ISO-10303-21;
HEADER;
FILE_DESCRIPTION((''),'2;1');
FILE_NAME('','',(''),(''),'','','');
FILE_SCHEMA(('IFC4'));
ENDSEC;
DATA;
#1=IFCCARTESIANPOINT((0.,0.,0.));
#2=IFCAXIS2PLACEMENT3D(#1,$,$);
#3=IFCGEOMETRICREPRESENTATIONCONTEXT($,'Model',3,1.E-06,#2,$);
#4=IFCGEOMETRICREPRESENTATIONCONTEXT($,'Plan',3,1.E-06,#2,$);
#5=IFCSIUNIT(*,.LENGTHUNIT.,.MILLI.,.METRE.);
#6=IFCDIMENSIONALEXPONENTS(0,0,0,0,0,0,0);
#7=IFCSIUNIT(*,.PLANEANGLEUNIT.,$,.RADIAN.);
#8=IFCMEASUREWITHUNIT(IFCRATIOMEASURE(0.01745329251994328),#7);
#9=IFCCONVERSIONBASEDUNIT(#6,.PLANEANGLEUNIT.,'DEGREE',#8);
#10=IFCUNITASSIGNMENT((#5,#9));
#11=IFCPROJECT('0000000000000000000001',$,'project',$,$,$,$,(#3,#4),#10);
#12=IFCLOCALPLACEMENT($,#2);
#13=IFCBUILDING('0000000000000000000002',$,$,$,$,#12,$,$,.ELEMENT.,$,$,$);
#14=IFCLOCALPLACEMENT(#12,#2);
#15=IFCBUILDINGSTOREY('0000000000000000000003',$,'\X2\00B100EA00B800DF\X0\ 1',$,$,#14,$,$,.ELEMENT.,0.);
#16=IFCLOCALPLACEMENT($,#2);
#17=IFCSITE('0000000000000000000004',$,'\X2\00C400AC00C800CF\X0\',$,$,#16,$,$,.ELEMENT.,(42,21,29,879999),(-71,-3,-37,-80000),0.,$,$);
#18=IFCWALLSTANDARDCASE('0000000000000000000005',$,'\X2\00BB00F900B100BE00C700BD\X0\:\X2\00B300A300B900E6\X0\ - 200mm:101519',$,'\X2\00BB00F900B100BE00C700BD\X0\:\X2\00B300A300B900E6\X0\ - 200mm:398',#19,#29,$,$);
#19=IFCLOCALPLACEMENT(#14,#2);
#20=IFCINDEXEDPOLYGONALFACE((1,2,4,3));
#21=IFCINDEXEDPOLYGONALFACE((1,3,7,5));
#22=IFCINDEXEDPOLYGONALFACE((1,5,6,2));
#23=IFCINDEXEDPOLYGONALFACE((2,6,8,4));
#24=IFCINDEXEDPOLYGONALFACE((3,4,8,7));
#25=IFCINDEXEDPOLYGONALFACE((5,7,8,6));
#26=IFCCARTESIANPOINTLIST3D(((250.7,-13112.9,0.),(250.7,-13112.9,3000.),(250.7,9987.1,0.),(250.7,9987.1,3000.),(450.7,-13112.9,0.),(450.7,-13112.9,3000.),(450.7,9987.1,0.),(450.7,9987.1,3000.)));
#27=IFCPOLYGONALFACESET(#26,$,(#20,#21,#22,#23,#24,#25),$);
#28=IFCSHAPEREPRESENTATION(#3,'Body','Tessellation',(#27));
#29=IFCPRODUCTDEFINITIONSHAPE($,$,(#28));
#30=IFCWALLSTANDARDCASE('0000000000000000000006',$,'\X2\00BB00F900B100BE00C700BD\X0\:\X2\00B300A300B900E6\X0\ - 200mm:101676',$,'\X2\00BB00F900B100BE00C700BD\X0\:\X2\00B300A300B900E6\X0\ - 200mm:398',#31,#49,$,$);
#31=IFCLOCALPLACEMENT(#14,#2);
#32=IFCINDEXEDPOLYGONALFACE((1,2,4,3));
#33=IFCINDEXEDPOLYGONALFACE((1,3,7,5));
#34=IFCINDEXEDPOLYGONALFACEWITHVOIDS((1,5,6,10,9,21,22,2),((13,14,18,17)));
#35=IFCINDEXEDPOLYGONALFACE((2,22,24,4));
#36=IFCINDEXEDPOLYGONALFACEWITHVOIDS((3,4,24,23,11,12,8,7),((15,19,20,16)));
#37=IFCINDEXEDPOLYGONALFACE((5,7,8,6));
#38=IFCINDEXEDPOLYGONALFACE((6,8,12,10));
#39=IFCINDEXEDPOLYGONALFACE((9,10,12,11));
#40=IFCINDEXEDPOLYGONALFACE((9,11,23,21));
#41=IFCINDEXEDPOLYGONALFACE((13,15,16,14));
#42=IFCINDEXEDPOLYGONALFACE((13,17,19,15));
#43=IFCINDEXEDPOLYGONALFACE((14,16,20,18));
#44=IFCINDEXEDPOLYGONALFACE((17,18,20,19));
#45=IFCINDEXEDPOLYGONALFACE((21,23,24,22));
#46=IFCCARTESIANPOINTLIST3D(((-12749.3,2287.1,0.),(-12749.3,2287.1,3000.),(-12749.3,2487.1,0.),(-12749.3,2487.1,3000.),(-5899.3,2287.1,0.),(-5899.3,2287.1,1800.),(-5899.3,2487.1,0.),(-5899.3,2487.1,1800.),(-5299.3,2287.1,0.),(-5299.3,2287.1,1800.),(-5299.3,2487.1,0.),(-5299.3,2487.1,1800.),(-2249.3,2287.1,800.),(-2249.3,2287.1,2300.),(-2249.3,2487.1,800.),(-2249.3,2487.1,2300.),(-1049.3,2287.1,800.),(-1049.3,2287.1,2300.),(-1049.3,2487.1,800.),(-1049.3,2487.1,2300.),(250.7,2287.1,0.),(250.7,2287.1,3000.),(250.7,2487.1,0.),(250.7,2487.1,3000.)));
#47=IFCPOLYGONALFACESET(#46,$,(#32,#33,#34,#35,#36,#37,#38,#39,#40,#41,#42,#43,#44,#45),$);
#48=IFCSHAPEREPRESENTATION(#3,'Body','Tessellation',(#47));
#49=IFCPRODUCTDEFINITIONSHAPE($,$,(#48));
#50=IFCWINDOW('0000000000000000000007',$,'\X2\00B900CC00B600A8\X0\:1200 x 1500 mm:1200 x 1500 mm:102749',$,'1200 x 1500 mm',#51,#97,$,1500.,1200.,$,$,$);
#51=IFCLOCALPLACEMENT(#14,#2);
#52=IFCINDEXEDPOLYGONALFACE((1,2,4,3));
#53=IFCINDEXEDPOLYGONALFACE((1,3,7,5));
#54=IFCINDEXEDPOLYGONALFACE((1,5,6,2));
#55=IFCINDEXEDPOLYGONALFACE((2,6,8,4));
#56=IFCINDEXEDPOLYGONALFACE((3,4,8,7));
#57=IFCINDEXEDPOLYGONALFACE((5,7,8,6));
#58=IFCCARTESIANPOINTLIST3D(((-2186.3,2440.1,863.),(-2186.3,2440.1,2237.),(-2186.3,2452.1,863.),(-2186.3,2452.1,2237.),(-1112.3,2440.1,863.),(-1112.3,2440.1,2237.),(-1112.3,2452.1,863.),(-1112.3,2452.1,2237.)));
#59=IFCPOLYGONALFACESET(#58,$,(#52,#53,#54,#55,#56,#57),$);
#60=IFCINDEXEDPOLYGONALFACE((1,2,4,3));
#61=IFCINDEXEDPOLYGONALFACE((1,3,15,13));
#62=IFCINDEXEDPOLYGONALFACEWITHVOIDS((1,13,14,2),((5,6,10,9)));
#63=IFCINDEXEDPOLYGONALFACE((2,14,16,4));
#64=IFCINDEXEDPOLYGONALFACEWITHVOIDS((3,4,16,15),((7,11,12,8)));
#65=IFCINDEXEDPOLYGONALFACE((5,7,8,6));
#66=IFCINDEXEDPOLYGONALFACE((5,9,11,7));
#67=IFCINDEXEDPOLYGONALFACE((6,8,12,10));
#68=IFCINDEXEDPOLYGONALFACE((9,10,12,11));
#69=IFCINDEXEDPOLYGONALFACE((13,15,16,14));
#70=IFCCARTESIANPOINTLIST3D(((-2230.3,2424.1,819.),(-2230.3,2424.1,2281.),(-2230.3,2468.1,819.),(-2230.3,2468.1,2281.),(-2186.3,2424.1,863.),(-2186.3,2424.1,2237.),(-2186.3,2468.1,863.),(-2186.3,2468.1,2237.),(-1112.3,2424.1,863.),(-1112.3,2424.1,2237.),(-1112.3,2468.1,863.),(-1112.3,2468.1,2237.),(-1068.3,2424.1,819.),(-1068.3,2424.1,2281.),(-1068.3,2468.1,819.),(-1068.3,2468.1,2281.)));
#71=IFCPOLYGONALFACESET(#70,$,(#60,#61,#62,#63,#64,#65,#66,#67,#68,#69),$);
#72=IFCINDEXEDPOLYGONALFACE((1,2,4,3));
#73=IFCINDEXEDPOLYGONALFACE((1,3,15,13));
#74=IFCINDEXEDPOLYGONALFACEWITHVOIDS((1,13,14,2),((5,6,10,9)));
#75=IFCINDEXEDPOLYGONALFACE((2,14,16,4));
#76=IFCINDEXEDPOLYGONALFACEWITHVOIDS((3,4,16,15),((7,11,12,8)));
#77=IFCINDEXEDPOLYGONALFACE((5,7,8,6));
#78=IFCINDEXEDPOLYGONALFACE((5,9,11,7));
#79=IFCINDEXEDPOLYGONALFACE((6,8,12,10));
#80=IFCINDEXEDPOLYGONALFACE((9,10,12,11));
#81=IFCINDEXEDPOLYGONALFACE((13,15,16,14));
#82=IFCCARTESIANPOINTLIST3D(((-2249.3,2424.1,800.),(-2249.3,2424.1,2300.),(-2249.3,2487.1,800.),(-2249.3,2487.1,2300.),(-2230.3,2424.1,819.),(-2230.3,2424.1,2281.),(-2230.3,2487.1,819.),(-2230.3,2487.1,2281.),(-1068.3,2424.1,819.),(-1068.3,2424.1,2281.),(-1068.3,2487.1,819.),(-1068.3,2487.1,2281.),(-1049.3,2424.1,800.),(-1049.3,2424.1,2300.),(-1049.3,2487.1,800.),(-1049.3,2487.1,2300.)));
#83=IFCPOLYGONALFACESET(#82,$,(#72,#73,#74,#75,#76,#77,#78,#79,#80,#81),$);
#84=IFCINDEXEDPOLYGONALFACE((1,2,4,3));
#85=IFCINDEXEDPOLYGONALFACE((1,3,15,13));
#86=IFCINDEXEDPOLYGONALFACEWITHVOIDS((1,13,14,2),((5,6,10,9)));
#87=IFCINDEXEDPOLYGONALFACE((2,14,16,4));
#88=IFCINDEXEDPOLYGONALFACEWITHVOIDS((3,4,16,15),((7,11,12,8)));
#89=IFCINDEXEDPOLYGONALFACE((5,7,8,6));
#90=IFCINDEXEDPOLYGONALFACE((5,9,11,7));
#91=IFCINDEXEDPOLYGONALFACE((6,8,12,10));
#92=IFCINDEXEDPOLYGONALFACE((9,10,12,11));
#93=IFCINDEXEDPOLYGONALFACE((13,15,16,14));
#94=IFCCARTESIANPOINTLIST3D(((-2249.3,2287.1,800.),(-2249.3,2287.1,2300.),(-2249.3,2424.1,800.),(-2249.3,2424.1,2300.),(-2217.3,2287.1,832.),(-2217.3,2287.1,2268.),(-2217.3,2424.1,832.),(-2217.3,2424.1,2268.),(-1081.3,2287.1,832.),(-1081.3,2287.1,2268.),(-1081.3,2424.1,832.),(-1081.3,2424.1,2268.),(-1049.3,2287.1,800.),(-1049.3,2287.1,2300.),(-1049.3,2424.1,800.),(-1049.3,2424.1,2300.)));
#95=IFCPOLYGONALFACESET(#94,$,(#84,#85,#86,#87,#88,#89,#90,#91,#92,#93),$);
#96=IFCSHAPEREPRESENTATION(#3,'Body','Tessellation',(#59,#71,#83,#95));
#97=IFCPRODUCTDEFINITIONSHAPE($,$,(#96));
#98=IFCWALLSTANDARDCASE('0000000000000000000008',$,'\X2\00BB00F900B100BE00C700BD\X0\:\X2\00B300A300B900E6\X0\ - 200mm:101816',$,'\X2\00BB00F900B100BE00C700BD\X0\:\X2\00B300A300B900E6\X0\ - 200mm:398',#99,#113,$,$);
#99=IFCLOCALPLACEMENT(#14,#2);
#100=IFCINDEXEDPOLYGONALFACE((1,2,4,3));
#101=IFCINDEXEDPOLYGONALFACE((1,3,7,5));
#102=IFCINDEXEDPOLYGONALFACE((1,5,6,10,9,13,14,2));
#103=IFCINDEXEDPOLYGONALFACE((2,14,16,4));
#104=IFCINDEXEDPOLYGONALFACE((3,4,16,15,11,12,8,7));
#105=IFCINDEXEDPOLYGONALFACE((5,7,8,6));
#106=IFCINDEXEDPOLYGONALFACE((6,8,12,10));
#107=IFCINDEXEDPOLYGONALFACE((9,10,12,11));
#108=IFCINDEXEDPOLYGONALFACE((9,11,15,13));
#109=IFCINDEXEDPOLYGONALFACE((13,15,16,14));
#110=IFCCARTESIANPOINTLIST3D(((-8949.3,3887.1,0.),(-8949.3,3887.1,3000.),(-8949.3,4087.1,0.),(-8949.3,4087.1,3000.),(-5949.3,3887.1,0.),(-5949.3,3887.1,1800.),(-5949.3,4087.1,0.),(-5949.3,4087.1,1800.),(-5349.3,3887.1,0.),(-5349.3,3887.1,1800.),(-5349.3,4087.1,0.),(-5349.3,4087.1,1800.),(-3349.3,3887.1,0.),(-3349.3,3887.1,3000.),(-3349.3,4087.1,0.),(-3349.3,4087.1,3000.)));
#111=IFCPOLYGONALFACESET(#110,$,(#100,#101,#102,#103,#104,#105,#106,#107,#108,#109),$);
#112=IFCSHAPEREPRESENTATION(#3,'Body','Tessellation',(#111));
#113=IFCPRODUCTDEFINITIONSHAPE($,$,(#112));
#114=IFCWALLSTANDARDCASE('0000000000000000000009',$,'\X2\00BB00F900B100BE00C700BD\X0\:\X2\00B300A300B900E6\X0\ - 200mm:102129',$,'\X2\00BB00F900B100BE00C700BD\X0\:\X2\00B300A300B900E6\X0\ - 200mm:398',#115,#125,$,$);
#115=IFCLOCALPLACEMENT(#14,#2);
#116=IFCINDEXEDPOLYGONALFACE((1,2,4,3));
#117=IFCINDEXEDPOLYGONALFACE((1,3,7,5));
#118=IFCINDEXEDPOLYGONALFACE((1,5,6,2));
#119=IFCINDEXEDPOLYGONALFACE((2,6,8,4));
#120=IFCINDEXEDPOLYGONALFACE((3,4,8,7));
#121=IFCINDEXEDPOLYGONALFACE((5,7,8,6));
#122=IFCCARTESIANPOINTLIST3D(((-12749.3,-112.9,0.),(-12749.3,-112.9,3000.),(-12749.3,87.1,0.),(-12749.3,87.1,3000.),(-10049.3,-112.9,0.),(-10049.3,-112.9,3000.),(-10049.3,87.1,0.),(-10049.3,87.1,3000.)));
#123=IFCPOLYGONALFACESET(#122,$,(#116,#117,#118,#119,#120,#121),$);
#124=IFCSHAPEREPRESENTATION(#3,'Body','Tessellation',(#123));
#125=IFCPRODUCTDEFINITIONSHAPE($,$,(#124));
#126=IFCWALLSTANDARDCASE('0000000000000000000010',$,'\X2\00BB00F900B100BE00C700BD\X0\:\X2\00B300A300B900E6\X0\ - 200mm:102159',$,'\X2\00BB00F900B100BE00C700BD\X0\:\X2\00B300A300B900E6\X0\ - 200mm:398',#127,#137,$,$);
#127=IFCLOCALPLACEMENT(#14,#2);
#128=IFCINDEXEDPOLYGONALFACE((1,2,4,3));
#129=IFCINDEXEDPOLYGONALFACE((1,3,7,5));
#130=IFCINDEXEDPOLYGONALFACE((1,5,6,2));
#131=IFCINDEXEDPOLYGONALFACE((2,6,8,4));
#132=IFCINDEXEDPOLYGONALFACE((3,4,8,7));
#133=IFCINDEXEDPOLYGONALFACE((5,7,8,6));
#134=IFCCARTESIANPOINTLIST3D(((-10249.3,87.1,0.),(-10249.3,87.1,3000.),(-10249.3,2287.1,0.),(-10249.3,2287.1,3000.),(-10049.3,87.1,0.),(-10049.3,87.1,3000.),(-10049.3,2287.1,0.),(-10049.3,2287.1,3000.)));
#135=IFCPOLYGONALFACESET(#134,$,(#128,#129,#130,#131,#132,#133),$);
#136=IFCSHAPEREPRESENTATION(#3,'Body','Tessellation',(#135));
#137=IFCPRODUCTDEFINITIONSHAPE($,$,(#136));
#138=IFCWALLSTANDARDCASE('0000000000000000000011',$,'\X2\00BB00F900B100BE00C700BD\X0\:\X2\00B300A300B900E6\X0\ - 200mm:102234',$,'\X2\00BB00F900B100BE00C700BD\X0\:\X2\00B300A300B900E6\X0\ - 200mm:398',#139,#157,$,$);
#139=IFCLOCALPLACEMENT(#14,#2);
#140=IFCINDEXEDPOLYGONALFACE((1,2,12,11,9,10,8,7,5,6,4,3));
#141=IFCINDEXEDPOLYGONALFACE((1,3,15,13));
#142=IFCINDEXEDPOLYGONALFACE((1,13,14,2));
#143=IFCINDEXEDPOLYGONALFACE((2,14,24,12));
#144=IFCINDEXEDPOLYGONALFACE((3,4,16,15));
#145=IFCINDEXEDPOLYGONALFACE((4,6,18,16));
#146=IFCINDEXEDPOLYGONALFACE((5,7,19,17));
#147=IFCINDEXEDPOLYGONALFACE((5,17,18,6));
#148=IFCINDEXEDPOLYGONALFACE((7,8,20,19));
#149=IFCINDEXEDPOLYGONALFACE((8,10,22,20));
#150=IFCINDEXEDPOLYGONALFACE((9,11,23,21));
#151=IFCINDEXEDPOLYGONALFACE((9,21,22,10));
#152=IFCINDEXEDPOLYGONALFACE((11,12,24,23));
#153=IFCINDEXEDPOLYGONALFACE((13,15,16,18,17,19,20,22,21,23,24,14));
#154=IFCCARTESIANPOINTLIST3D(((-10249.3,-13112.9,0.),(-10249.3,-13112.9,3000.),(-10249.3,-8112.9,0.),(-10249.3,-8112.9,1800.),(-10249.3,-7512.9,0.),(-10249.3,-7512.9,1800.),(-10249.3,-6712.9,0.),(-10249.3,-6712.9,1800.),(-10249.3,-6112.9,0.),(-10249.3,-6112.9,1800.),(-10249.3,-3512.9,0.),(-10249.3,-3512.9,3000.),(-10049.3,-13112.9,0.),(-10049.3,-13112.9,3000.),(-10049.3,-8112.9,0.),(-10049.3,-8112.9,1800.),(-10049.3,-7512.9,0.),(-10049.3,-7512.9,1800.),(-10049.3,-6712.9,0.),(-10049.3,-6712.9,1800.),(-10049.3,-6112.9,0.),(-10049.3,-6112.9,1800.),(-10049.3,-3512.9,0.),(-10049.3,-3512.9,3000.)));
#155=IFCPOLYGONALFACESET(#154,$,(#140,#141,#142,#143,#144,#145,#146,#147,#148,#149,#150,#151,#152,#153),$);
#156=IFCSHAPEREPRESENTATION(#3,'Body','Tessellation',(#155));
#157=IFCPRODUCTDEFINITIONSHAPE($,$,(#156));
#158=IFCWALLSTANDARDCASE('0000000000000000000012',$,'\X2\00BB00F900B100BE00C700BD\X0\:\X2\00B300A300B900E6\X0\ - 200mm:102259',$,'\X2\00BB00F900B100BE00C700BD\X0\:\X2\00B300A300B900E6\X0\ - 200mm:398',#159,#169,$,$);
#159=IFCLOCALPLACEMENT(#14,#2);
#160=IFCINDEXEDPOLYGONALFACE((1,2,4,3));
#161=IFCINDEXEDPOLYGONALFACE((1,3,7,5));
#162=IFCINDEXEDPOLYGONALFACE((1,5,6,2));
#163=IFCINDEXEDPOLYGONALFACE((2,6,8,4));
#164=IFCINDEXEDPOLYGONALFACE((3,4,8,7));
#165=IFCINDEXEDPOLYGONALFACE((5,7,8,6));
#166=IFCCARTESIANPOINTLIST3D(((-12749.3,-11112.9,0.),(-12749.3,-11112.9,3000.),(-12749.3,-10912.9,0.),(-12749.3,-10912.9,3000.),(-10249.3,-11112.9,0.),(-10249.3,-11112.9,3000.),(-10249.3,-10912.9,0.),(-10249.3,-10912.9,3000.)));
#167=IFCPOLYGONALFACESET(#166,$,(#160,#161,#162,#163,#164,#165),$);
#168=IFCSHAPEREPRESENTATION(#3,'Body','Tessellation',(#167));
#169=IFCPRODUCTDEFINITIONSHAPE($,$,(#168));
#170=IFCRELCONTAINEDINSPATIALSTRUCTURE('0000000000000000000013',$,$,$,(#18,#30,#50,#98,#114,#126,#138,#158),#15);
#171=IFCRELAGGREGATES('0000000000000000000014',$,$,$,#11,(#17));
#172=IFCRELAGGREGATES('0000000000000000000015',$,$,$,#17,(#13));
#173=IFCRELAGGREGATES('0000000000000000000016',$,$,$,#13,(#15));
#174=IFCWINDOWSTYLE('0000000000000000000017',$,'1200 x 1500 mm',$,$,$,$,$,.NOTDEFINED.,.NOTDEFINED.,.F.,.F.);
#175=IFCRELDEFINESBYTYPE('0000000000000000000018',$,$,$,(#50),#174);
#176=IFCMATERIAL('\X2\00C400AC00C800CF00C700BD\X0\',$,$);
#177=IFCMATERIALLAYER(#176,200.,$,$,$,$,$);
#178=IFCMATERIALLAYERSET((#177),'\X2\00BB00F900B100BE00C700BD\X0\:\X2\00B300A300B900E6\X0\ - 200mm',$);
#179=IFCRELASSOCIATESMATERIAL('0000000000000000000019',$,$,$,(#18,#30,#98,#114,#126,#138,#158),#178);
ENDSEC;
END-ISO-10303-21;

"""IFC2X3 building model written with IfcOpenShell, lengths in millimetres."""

from ifc_helpers import new_model, entity, si_unit, converted_unit, frame, frame_2d, origin, origin_2d_with_axis, place, context, project, spatial, polyline, rectangle, outline, extrude, source, transform, mapped, material, layer, layer_set, layer_usage, type_object, type_shapes, element, fill, save


model = new_model("IFC2X3")

# Units and contexts
model_context = context("Model", 3, precision=1e-06, world=origin())
plan_context = context("Plan", 3, precision=1e-06, world=origin())
ifc_project = project(units=[si_unit("LENGTHUNIT", "METRE", prefix="MILLI"), converted_unit("PLANEANGLEUNIT", "DEGREE", entity("IfcRatioMeasure", 0.01745329251994328), si_unit("PLANEANGLEUNIT", "RADIAN"), dimensions=[0, 0, 0, 0, 0, 0, 0])], contexts=[model_context, plan_context])

# Site, building, storey
site_placement = place(None, origin())
site = spatial("IfcSite", under=ifc_project, at=site_placement, Name="Ä¬ÈÏ", CompositionType="ELEMENT", RefLatitude=(42, 21, 29, 879999), RefLongitude=(-71, -3, -37, -80000), RefElevation=0.0)
building_placement = place(None, origin())
building = spatial("IfcBuilding", under=site, at=building_placement, CompositionType="ELEMENT")
storey_placement = place(building_placement, origin())
storey = spatial("IfcBuildingStorey", under=building, at=storey_placement, Name="±ê¸ß 1", CompositionType="ELEMENT", Elevation=0.0)

# Shared definitions
ifc_material_1 = material(Name="Ä¬ÈÏÇ½")
ifc_layer_1 = layer(ifc_material_1, 200.0)
ifc_layer_set_1 = layer_set([ifc_layer_1], Name="»ù±¾Ç½:³£¹æ - 200mm")
window_style = type_object("IfcWindowStyle", Name="1200 x 1500 mm", ConstructionType="NOTDEFINED", OperationType="NOTDEFINED", ParameterTakesPrecedence=False, Sizeable=False)
shared_shape = source(origin(), model_context, "Body", "SweptSolid", [
    extrude(rectangle(XDim=12.0, YDim=1074.0, at=origin_2d_with_axis()), frame((600.0, 159.0, 63.0), z_axis=(0.0, 0.0, 1.0), x_axis=(0.0, -1.0, 0.0)), (0.0, 0.0, 1.0), 1374.0),
    extrude(outline(polyline([(-581.0, -731.0), (581.0, -731.0), (581.0, 731.0), (-581.0, 731.0), (-581.0, -731.0)]), holes=[polyline([(-537.0, -687.0), (-537.0, 687.0), (537.0, 687.0), (537.0, -687.0), (-537.0, -687.0)])]), frame((600.0, 137.0, 750.0), z_axis=(0.0, 1.0, 0.0), x_axis=(1.0, 0.0, 0.0)), (0.0, 0.0, 1.0), 44.0),
    extrude(outline(polyline([(-600.0, -750.0), (600.0, -750.0), (600.0, 750.0), (-600.0, 750.0), (-600.0, -750.0)]), holes=[polyline([(-581.0, -731.0), (-581.0, 731.0), (581.0, 731.0), (581.0, -731.0), (-581.0, -731.0)])]), frame((600.0, 137.0, 750.0), z_axis=(0.0, 1.0, 0.0), x_axis=(1.0, 0.0, 0.0)), (0.0, 0.0, 1.0), 63.0),
    extrude(outline(polyline([(-600.0, -750.0), (600.0, -750.0), (600.0, 750.0), (-600.0, 750.0), (-600.0, -750.0)]), holes=[polyline([(-568.0, -718.0), (-568.0, 718.0), (568.0, 718.0), (568.0, -718.0), (-568.0, -718.0)])]), frame((600.0, 0.0, 750.0), z_axis=(0.0, 1.0, 0.0), x_axis=(1.0, 0.0, 0.0)), (0.0, 0.0, 1.0), 137.0),
])
type_shapes(window_style, [shared_shape])

# Wall
ifc_layer_usage_1 = layer_usage(ifc_layer_set_1, "AXIS2", "NEGATIVE", 100.0)
wall_1_placement = place(storey_placement, frame((350.7, -13112.9, 0.0), z_axis=(0.0, 0.0, 1.0), x_axis=(0.0, 1.0, 0.0)))
element("IfcWallStandardCase", 1, at=wall_1_placement, inside=storey, material=ifc_layer_usage_1, Name="»ù±¾Ç½:³£¹æ - 200mm:101519", ObjectType="»ù±¾Ç½:³£¹æ - 200mm:398", context=model_context, shape_type="SweptSolid", body=[
    extrude(rectangle(XDim=23100.0, YDim=200.0, at=frame_2d((11550.0, 0.0), x_axis=(-1.0, 0.0))), origin(), (0.0, 0.0, 1.0), 3000.0),
])

# Wall, openings, window
ifc_layer_usage_2 = layer_usage(ifc_layer_set_1, "AXIS2", "NEGATIVE", 100.0)
wall_2_placement = place(storey_placement, frame((-12749.3, 2387.1, 0.0)))
wall_2 = element("IfcWallStandardCase", 2, at=wall_2_placement, inside=storey, material=ifc_layer_usage_2, Name="»ù±¾Ç½:³£¹æ - 200mm:101676", ObjectType="»ù±¾Ç½:³£¹æ - 200mm:398", context=model_context, shape_type="SweptSolid", body=[
    extrude(rectangle(XDim=13000.0, YDim=200.0, at=frame_2d((6500.0, 0.0), x_axis=(-1.0, 0.0))), origin(), (0.0, 0.0, 1.0), 3000.0),
])
opening_1_placement = place(wall_2_placement, frame((10500.0, -100.0, 800.0)))
opening_1 = element("IfcOpeningElement", 3, at=opening_1_placement, cuts=wall_2, ObjectType="Opening", context=model_context, shape_type="SweptSolid", body=[
    extrude(rectangle(XDim=1500.0, YDim=1200.0, at=frame_2d((750.0, 600.0), x_axis=(1.0, 0.0))), frame((0.0, 0.0, 0.0), z_axis=(0.0, 1.0, 0.0), x_axis=(0.0, 0.0, 1.0)), (0.0, 0.0, 1.0), 200.0),
])
opening_2_placement = place(wall_2_placement, frame((7450.0, 100.0, 0.0)))
element("IfcOpeningElement", 4, at=opening_2_placement, cuts=wall_2, ObjectType="Opening", context=model_context, shape_type="SweptSolid", body=[
    extrude(rectangle(XDim=1800.0, YDim=600.0, at=frame_2d((900.0, 300.0), x_axis=(1.0, 0.0))), frame((0.0, 0.0, 0.0), z_axis=(0.0, -1.0, 0.0), x_axis=(0.0, 0.0, 1.0)), (0.0, 0.0, 1.0), 200.0),
])
window_1_placement = place(opening_1_placement, origin())
window_1 = element("IfcWindow", 5, at=window_1_placement, inside=storey, type_object=window_style, Name="¹Ì¶¨:1200 x 1500 mm:1200 x 1500 mm:102749", ObjectType="1200 x 1500 mm", OverallHeight=1500.0, OverallWidth=1200.0, context=model_context, shape_type="MappedRepresentation", body=[
    mapped(shared_shape, transform((0.0, 0.0, 0.0), scale=1.0)),
])
fill(opening_1, window_1)

# Wall, opening
ifc_layer_usage_3 = layer_usage(ifc_layer_set_1, "AXIS2", "NEGATIVE", 100.0)
wall_3_placement = place(storey_placement, frame((-8949.3, 3987.1, 0.0)))
wall_3 = element("IfcWallStandardCase", 6, at=wall_3_placement, inside=storey, material=ifc_layer_usage_3, Name="»ù±¾Ç½:³£¹æ - 200mm:101816", ObjectType="»ù±¾Ç½:³£¹æ - 200mm:398", context=model_context, shape_type="SweptSolid", body=[
    extrude(rectangle(XDim=5600.0, YDim=200.0, at=frame_2d((2800.0, 0.0), x_axis=(-1.0, 0.0))), origin(), (0.0, 0.0, 1.0), 3000.0),
])
opening_3_placement = place(wall_3_placement, frame((3000.0, -100.0, 0.0)))
element("IfcOpeningElement", 7, at=opening_3_placement, cuts=wall_3, ObjectType="Opening", context=model_context, shape_type="SweptSolid", body=[
    extrude(rectangle(XDim=1800.0, YDim=600.0, at=frame_2d((900.0, 300.0), x_axis=(1.0, 0.0))), frame((0.0, 0.0, 0.0), z_axis=(0.0, 1.0, 0.0), x_axis=(0.0, 0.0, 1.0)), (0.0, 0.0, 1.0), 200.0),
])

# Walls
ifc_layer_usage_4 = layer_usage(ifc_layer_set_1, "AXIS2", "NEGATIVE", 100.0)
wall_4_placement = place(storey_placement, frame((-12749.3, -12.9, 0.0)))
element("IfcWallStandardCase", 8, at=wall_4_placement, inside=storey, material=ifc_layer_usage_4, Name="»ù±¾Ç½:³£¹æ - 200mm:102129", ObjectType="»ù±¾Ç½:³£¹æ - 200mm:398", context=model_context, shape_type="SweptSolid", body=[
    extrude(rectangle(XDim=2700.0, YDim=200.0, at=frame_2d((1350.0, 0.0), x_axis=(-1.0, 0.0))), origin(), (0.0, 0.0, 1.0), 3000.0),
])
ifc_layer_usage_5 = layer_usage(ifc_layer_set_1, "AXIS2", "NEGATIVE", 100.0)
wall_5_placement = place(storey_placement, frame((-10149.3, 87.1, 0.0), z_axis=(0.0, 0.0, 1.0), x_axis=(0.0, 1.0, 0.0)))
element("IfcWallStandardCase", 9, at=wall_5_placement, inside=storey, material=ifc_layer_usage_5, Name="»ù±¾Ç½:³£¹æ - 200mm:102159", ObjectType="»ù±¾Ç½:³£¹æ - 200mm:398", context=model_context, shape_type="SweptSolid", body=[
    extrude(rectangle(XDim=2200.0, YDim=200.0, at=frame_2d((1100.0, 0.0), x_axis=(-1.0, 0.0))), origin(), (0.0, 0.0, 1.0), 3000.0),
])

# Wall, openings
ifc_layer_usage_6 = layer_usage(ifc_layer_set_1, "AXIS2", "NEGATIVE", 100.0)
wall_6_placement = place(storey_placement, frame((-10149.3, -3512.9, 0.0), z_axis=(0.0, 0.0, 1.0), x_axis=(0.0, -1.0, 0.0)))
wall_6 = element("IfcWallStandardCase", 10, at=wall_6_placement, inside=storey, material=ifc_layer_usage_6, Name="»ù±¾Ç½:³£¹æ - 200mm:102234", ObjectType="»ù±¾Ç½:³£¹æ - 200mm:398", context=model_context, shape_type="SweptSolid", body=[
    extrude(rectangle(XDim=9600.0, YDim=200.0, at=frame_2d((4800.0, 0.0), x_axis=(-1.0, 0.0))), origin(), (0.0, 0.0, 1.0), 3000.0),
])
opening_4_placement = place(wall_6_placement, frame((2600.0, -100.0, 0.0)))
element("IfcOpeningElement", 11, at=opening_4_placement, cuts=wall_6, ObjectType="Opening", context=model_context, shape_type="SweptSolid", body=[
    extrude(rectangle(XDim=1800.0, YDim=600.0, at=frame_2d((900.0, 300.0), x_axis=(1.0, 0.0))), frame((0.0, 0.0, 0.0), z_axis=(0.0, 1.0, 0.0), x_axis=(0.0, 0.0, 1.0)), (0.0, 0.0, 1.0), 200.0),
])
opening_5_placement = place(wall_6_placement, frame((4000.0, -100.0, 0.0)))
element("IfcOpeningElement", 12, at=opening_5_placement, cuts=wall_6, ObjectType="Opening", context=model_context, shape_type="SweptSolid", body=[
    extrude(rectangle(XDim=1800.0, YDim=600.0, at=frame_2d((900.0, 300.0), x_axis=(1.0, 0.0))), frame((0.0, 0.0, 0.0), z_axis=(0.0, 1.0, 0.0), x_axis=(0.0, 0.0, 1.0)), (0.0, 0.0, 1.0), 200.0),
])

# Wall
ifc_layer_usage_7 = layer_usage(ifc_layer_set_1, "AXIS2", "NEGATIVE", 100.0)
wall_7_placement = place(storey_placement, frame((-12749.3, -11012.9, 0.0)))
element("IfcWallStandardCase", 13, at=wall_7_placement, inside=storey, material=ifc_layer_usage_7, Name="»ù±¾Ç½:³£¹æ - 200mm:102259", ObjectType="»ù±¾Ç½:³£¹æ - 200mm:398", context=model_context, shape_type="SweptSolid", body=[
    extrude(rectangle(XDim=2500.0, YDim=200.0, at=frame_2d((1250.0, 0.0), x_axis=(-1.0, 0.0))), origin(), (0.0, 0.0, 1.0), 3000.0),
])

save(model, "model.ifc")
